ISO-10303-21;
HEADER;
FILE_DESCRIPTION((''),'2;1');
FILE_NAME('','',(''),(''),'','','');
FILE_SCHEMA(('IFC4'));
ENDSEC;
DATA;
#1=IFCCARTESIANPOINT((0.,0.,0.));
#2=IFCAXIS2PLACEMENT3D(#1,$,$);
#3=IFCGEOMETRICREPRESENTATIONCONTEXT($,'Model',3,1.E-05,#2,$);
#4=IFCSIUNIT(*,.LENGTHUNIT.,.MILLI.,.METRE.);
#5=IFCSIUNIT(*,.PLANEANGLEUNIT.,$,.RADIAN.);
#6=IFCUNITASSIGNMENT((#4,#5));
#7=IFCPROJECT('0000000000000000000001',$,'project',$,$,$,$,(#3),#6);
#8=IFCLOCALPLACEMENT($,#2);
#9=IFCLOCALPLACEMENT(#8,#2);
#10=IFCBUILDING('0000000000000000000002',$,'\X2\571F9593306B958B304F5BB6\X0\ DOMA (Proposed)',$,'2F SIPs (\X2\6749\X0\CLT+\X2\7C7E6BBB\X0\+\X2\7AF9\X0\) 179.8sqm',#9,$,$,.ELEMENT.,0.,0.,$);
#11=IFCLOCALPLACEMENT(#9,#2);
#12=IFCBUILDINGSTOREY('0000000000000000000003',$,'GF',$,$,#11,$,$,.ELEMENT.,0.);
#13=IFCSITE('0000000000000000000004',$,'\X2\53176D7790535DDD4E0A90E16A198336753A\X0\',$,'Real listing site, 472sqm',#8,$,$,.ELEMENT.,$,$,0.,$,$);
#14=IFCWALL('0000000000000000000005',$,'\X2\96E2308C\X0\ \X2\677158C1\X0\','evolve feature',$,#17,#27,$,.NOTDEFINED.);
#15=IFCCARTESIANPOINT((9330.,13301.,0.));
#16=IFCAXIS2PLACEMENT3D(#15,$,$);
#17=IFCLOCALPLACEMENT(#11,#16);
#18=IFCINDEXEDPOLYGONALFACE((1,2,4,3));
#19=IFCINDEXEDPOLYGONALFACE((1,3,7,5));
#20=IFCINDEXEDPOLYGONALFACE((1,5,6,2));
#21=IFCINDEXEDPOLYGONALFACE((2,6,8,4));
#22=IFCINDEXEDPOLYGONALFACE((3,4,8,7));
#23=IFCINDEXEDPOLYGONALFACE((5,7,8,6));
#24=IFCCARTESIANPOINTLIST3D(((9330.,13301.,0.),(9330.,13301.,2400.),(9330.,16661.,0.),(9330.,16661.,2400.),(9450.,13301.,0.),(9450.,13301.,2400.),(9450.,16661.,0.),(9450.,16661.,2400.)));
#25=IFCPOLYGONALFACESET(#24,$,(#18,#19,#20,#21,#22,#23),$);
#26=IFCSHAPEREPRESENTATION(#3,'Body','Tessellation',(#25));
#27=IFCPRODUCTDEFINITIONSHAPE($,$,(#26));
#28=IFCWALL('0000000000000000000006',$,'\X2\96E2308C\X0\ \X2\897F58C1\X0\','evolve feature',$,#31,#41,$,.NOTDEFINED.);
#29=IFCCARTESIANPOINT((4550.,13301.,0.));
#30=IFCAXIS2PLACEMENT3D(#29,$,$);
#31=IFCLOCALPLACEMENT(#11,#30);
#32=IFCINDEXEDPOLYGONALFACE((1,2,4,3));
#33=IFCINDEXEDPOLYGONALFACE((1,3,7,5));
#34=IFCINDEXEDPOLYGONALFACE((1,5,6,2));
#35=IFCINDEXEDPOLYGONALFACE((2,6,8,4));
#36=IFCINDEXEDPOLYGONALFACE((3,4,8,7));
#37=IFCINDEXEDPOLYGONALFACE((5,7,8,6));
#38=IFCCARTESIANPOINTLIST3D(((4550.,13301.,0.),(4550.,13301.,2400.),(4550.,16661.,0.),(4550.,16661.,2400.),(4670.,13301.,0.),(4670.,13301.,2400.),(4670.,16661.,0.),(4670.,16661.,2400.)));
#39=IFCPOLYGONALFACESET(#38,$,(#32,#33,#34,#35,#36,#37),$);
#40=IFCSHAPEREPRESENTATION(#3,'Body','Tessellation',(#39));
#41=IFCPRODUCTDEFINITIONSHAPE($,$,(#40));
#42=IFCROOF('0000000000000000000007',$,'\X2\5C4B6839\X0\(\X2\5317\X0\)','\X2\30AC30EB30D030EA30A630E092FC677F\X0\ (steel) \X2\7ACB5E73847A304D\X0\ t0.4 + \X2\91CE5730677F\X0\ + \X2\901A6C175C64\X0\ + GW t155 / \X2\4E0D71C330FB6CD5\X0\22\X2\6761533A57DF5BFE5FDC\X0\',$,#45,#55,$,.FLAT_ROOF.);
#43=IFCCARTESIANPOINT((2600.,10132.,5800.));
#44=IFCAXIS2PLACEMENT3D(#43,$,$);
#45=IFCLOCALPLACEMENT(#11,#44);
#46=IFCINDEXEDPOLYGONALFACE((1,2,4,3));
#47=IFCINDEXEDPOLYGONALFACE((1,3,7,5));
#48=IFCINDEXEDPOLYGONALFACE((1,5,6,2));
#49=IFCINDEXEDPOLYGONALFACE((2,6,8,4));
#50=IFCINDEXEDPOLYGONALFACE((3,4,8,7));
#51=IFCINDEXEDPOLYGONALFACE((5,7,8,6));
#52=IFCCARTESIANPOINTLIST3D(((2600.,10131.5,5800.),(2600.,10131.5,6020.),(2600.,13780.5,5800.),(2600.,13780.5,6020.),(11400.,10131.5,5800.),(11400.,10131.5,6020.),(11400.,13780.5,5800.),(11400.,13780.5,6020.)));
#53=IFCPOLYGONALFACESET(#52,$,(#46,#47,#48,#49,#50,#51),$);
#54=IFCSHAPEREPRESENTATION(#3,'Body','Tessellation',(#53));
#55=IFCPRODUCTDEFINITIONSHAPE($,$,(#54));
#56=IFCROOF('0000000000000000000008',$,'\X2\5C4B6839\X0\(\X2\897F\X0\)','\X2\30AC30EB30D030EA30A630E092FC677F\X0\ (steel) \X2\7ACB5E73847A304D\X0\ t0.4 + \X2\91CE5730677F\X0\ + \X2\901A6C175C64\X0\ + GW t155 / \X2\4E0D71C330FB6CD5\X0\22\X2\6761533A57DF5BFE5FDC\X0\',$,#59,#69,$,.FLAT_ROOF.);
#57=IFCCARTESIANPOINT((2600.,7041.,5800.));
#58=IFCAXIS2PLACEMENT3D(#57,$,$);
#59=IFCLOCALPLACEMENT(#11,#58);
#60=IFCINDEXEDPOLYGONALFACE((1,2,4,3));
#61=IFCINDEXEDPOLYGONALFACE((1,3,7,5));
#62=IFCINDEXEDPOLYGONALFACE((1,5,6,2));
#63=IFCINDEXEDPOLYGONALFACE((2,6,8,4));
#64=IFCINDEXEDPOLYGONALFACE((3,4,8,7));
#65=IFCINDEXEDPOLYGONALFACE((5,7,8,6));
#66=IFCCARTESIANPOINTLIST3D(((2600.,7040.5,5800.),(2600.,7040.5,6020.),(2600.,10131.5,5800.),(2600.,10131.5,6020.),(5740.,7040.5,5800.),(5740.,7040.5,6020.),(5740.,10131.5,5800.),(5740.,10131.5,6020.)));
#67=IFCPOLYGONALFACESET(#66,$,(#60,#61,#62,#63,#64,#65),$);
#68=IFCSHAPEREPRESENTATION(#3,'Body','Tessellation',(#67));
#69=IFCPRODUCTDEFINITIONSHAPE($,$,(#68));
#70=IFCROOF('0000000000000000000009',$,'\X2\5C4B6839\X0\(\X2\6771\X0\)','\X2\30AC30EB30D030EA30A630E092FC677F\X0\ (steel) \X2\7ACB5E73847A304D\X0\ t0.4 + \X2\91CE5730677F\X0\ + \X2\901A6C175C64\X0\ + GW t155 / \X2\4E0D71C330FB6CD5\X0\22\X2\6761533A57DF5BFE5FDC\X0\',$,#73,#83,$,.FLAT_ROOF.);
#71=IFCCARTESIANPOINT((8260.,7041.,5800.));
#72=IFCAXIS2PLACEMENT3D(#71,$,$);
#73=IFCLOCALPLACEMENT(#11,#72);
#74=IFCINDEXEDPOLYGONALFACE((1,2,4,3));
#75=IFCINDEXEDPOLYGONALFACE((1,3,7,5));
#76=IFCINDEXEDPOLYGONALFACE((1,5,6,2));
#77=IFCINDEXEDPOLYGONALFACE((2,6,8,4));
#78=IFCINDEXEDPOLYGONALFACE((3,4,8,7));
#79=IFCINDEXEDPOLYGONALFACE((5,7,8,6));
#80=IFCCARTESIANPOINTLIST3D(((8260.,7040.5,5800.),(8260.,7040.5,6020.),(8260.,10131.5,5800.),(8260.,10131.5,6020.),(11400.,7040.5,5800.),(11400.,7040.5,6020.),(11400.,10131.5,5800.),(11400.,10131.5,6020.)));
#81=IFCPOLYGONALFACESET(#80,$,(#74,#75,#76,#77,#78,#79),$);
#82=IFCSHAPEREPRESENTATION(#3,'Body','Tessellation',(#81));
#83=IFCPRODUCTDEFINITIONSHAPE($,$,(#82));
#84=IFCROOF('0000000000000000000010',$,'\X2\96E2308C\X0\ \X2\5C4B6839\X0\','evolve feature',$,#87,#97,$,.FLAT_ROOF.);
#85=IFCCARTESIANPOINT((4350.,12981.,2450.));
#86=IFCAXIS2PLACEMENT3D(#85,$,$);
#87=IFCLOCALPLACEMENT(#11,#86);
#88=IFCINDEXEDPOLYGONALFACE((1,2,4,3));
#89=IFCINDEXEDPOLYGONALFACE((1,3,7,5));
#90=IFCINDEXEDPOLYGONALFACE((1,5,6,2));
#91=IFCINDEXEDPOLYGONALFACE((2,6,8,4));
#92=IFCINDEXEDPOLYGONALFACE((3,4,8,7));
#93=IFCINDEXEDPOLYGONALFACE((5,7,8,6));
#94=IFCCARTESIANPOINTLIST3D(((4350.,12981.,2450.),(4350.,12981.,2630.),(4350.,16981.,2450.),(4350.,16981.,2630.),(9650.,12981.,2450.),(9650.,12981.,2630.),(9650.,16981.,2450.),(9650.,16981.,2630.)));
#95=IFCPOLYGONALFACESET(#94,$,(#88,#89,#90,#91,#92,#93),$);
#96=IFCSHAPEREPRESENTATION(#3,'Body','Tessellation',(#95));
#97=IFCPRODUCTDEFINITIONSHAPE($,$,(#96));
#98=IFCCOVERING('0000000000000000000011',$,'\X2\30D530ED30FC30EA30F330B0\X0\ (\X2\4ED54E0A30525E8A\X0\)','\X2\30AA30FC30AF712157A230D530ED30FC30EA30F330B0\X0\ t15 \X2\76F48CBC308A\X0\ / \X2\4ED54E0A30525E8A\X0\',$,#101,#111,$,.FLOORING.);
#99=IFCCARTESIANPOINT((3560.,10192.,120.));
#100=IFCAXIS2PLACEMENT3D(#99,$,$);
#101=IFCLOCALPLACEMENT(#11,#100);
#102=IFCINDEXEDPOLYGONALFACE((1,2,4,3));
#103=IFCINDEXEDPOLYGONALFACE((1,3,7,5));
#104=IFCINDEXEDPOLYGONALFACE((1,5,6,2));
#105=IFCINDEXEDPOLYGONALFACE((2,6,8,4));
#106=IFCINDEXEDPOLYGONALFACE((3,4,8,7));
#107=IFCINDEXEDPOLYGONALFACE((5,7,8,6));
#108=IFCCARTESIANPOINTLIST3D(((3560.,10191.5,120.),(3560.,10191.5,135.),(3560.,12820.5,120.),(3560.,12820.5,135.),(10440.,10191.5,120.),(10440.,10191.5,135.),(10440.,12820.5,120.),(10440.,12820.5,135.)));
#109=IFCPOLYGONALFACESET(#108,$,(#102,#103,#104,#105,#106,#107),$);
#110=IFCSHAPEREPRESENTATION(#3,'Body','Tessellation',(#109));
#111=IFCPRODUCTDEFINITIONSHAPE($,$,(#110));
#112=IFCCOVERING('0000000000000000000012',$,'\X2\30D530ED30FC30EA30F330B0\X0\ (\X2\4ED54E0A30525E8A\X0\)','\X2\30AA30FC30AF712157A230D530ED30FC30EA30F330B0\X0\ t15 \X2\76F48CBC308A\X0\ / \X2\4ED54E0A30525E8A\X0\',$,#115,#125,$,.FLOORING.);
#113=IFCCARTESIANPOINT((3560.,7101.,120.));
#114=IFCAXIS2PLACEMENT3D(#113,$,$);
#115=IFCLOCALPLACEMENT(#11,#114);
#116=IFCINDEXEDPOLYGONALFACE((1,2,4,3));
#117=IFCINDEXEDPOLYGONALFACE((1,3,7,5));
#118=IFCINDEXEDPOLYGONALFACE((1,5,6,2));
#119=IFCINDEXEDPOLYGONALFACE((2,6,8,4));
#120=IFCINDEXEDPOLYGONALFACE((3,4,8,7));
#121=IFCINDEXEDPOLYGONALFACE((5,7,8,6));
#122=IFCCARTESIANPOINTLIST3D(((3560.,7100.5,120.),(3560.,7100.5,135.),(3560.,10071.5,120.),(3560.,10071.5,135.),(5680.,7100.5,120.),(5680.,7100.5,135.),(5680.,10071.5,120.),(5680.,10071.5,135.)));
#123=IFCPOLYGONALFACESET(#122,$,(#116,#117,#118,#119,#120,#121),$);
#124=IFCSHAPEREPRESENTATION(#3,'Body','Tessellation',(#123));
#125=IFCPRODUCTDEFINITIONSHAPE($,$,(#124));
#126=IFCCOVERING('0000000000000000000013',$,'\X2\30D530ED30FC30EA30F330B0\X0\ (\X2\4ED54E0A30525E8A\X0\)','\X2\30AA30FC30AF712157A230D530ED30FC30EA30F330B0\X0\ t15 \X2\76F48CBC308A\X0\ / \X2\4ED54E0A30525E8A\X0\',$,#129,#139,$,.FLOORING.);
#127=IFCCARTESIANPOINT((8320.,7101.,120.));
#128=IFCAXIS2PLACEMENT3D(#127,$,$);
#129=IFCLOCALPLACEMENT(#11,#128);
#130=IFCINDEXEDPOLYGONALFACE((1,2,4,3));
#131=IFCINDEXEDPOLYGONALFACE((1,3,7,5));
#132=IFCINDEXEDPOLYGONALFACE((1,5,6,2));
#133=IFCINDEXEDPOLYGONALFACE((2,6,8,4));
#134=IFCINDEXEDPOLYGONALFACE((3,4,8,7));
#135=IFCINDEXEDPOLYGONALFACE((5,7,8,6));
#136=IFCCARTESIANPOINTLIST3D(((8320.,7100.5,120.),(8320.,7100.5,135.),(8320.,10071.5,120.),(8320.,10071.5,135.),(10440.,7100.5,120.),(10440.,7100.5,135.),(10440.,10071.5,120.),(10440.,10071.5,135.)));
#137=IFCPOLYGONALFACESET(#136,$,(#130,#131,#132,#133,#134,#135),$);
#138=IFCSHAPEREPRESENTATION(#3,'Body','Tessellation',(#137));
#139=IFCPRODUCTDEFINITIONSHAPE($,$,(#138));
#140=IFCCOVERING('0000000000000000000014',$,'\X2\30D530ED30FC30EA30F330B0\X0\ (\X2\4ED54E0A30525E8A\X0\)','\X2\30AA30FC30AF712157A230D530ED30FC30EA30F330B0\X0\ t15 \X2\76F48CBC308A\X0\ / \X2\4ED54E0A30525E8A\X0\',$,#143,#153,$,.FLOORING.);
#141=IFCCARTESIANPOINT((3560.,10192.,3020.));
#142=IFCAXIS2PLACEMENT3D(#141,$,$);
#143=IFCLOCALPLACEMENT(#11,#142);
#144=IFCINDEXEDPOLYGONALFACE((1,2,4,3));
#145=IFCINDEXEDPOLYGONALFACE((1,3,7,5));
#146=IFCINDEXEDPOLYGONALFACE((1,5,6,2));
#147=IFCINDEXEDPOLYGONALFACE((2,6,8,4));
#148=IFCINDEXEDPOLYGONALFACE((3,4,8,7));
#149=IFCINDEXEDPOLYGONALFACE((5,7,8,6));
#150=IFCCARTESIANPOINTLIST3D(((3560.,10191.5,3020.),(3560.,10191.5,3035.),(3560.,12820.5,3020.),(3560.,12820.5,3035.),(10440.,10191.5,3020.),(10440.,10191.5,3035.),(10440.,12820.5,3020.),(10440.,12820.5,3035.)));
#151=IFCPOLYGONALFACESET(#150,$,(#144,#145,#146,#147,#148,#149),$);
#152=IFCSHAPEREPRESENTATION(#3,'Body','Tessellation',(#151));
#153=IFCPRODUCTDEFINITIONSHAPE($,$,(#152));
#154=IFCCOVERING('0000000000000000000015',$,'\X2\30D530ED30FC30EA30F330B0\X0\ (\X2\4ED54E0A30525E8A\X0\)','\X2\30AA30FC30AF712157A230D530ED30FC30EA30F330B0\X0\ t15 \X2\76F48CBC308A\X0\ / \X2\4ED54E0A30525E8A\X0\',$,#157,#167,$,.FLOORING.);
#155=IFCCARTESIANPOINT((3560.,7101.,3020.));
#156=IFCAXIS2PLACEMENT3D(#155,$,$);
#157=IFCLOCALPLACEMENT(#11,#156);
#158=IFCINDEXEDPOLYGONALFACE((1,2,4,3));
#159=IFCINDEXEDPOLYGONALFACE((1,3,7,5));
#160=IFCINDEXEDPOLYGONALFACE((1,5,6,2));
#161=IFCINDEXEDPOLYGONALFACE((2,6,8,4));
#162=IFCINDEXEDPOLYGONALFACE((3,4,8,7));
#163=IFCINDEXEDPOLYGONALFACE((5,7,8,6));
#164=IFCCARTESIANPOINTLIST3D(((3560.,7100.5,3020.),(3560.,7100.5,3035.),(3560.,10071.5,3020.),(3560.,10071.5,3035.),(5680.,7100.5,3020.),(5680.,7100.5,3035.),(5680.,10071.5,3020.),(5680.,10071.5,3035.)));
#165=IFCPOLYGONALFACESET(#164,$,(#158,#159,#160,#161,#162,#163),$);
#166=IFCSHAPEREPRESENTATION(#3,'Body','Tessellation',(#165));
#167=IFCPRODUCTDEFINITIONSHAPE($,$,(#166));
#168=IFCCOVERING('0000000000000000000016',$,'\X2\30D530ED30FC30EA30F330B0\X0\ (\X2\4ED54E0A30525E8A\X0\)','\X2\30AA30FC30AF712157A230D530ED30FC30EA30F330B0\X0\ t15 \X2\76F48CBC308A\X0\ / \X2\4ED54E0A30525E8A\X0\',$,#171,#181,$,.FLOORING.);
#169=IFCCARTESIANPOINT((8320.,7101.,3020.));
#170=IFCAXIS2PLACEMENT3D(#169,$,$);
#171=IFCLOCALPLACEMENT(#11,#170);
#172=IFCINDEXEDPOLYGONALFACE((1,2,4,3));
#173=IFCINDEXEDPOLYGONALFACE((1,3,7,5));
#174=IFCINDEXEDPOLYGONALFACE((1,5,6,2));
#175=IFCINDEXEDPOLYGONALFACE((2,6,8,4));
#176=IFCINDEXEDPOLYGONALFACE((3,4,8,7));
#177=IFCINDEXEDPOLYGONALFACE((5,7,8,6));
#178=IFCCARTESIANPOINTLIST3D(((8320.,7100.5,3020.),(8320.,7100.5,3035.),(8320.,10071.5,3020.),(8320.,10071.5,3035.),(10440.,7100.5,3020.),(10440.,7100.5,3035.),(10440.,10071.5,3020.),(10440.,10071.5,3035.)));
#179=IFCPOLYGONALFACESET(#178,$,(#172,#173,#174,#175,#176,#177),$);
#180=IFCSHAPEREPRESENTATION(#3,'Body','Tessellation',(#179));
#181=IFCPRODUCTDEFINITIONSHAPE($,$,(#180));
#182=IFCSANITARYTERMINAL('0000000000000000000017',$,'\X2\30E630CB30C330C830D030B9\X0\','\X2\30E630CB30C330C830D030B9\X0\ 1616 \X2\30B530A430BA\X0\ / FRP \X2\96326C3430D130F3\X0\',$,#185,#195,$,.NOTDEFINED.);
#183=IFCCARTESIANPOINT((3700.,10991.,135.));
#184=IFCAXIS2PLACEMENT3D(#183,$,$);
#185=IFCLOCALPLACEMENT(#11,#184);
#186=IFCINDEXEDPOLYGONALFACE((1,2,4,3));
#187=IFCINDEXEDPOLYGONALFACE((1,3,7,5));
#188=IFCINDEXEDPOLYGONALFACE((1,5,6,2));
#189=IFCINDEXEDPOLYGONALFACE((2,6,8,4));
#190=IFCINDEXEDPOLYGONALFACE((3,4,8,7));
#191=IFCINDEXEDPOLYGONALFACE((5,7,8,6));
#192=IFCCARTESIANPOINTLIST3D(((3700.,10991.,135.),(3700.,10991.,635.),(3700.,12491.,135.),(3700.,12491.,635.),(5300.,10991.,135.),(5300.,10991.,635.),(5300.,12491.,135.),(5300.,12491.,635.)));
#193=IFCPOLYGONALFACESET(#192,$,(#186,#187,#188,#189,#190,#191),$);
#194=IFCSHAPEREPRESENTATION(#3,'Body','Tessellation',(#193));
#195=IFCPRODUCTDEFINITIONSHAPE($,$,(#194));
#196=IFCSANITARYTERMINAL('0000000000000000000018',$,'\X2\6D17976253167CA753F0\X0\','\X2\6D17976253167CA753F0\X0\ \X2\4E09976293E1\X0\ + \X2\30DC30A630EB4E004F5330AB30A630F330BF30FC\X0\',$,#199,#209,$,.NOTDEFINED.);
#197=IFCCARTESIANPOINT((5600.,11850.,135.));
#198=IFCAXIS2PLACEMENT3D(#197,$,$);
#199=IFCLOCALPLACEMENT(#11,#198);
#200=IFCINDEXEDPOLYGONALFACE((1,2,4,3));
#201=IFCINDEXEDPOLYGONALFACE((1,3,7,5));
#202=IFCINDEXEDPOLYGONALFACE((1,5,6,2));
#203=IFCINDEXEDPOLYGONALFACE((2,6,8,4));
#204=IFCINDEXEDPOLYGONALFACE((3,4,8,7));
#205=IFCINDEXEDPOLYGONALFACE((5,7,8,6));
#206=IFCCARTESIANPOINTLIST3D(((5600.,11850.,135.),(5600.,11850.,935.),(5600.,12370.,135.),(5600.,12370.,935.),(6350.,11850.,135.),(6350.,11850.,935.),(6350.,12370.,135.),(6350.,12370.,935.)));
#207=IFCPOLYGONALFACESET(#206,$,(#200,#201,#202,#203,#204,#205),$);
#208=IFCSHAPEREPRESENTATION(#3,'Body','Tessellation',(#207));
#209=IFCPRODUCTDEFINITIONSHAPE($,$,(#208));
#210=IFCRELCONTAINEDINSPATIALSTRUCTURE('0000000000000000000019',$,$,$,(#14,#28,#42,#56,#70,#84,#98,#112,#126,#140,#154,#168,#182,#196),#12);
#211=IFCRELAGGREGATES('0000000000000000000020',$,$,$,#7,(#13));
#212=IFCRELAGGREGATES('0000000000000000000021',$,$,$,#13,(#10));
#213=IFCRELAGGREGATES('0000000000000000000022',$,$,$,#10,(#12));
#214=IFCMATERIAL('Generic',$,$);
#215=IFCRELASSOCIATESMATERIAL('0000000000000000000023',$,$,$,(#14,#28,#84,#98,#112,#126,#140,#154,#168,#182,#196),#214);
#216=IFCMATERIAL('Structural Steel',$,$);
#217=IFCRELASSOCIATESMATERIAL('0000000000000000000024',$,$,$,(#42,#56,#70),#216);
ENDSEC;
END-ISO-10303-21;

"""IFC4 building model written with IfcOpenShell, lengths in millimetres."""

from ifc_helpers import new_model, si_unit, frame, frame_2d, origin, place, context, project, spatial, rectangle, extrude, material, element, save


model = new_model("IFC4")

# Units and contexts
model_context = context("Model", 3, precision=1e-05, world=origin())
ifc_project = project(units=[si_unit("LENGTHUNIT", "METRE", prefix="MILLI"), si_unit("PLANEANGLEUNIT", "RADIAN")], contexts=[model_context])

# Site, building, storey
site_placement = place(None, origin())
site = spatial("IfcSite", under=ifc_project, at=site_placement, Name="北海道川上郡標茶町", ObjectType="Real listing site, 472sqm", CompositionType="ELEMENT", RefElevation=0.0)
building_placement = place(site_placement, origin())
building = spatial("IfcBuilding", under=site, at=building_placement, Name="土間に開く家 DOMA (Proposed)", ObjectType="2F SIPs (杉CLT+籾殻+竹) 179.8sqm", CompositionType="ELEMENT", ElevationOfRefHeight=0.0, ElevationOfTerrain=0.0)
storey_placement = place(building_placement, origin())
storey = spatial("IfcBuildingStorey", under=building, at=storey_placement, Name="GF", CompositionType="ELEMENT", Elevation=0.0)

# Shared definitions
ifc_material_1 = material(Name="Generic")

# Walls
wall_1_placement = place(storey_placement, frame((9330.0, 13301.0, 0.0)))
element("IfcWall", 1, at=wall_1_placement, inside=storey, material=ifc_material_1, Name="離れ 東壁", Description="evolve feature", PredefinedType="NOTDEFINED", context=model_context, shape_type="SweptSolid", body=[
    extrude(rectangle(XDim=120.0, YDim=3360.0, at=frame_2d((60.0, 1680.0))), frame((9330.0, 13301.0, 0.0)), (0.0, 0.0, 1.0), 2400.0),
])
wall_2_placement = place(storey_placement, frame((4550.0, 13301.0, 0.0)))
element("IfcWall", 2, at=wall_2_placement, inside=storey, material=ifc_material_1, Name="離れ 西壁", Description="evolve feature", PredefinedType="NOTDEFINED", context=model_context, shape_type="SweptSolid", body=[
    extrude(rectangle(XDim=120.0, YDim=3360.0, at=frame_2d((60.0, 1680.0))), frame((4550.0, 13301.0, 0.0)), (0.0, 0.0, 1.0), 2400.0),
])

# Roofs
ifc_material_2 = material(Name="Structural Steel")
for number, where, name in (
    (3, (2600.0, 10132.0, 5800.0), "屋根(北)"),
):
    element("IfcRoof", number, at=place(storey_placement, frame(where)), inside=storey, material=ifc_material_2, Name=name, Description="ガルバリウム鋼板 (steel) 立平葺き t0.4 + 野地板 + 通気層 + GW t155 / 不燃・法22条区域対応", PredefinedType="FLAT_ROOF", context=model_context, shape_type="SweptSolid", body=[
        extrude(rectangle(XDim=8800.0, YDim=3649.0, at=frame_2d((4400.0, 1824.0))), frame((2600.0, 10132.0, 5800.0)), (0.0, 0.0, 1.0), 220.0),
    ])
roof_1_placement = place(storey_placement, frame((2600.0, 7041.0, 5800.0)))
element("IfcRoof", 4, at=roof_1_placement, inside=storey, material=ifc_material_2, Name="屋根(西)", Description="ガルバリウム鋼板 (steel) 立平葺き t0.4 + 野地板 + 通気層 + GW t155 / 不燃・法22条区域対応", PredefinedType="FLAT_ROOF", context=model_context, shape_type="SweptSolid", body=[
    extrude(rectangle(XDim=3140.0, YDim=3091.0, at=frame_2d((1570.0, 1545.0))), frame((2600.0, 7041.0, 5800.0)), (0.0, 0.0, 1.0), 220.0),
])
roof_2_placement = place(storey_placement, frame((8260.0, 7041.0, 5800.0)))
element("IfcRoof", 5, at=roof_2_placement, inside=storey, material=ifc_material_2, Name="屋根(東)", Description="ガルバリウム鋼板 (steel) 立平葺き t0.4 + 野地板 + 通気層 + GW t155 / 不燃・法22条区域対応", PredefinedType="FLAT_ROOF", context=model_context, shape_type="SweptSolid", body=[
    extrude(rectangle(XDim=3140.0, YDim=3091.0, at=frame_2d((1570.0, 1545.0))), frame((8260.0, 7041.0, 5800.0)), (0.0, 0.0, 1.0), 220.0),
])
roof_3_placement = place(storey_placement, frame((4350.0, 12981.0, 2450.0)))
element("IfcRoof", 6, at=roof_3_placement, inside=storey, material=ifc_material_1, Name="離れ 屋根", Description="evolve feature", PredefinedType="FLAT_ROOF", context=model_context, shape_type="SweptSolid", body=[
    extrude(rectangle(XDim=5300.0, YDim=4000.0, at=frame_2d((2650.0, 2000.0))), frame((4350.0, 12981.0, 2450.0)), (0.0, 0.0, 1.0), 180.0),
])

# Coverings
covering_1_placement = place(storey_placement, frame((3560.0, 10192.0, 120.0)))
element("IfcCovering", 7, at=covering_1_placement, inside=storey, material=ifc_material_1, Name="フローリング (仕上げ床)", Description="オーク無垢フローリング t15 直貼り / 仕上げ床", PredefinedType="FLOORING", context=model_context, shape_type="SweptSolid", body=[
    extrude(rectangle(XDim=6880.0, YDim=2629.0, at=frame_2d((3440.0, 1314.0))), frame((3560.0, 10192.0, 120.0)), (0.0, 0.0, 1.0), 15.0),
])
covering_2_placement = place(storey_placement, frame((3560.0, 7101.0, 120.0)))
element("IfcCovering", 8, at=covering_2_placement, inside=storey, material=ifc_material_1, Name="フローリング (仕上げ床)", Description="オーク無垢フローリング t15 直貼り / 仕上げ床", PredefinedType="FLOORING", context=model_context, shape_type="SweptSolid", body=[
    extrude(rectangle(XDim=2120.0, YDim=2971.0, at=frame_2d((1060.0, 1485.0))), frame((3560.0, 7101.0, 120.0)), (0.0, 0.0, 1.0), 15.0),
])
covering_3_placement = place(storey_placement, frame((8320.0, 7101.0, 120.0)))
element("IfcCovering", 9, at=covering_3_placement, inside=storey, material=ifc_material_1, Name="フローリング (仕上げ床)", Description="オーク無垢フローリング t15 直貼り / 仕上げ床", PredefinedType="FLOORING", context=model_context, shape_type="SweptSolid", body=[
    extrude(rectangle(XDim=2120.0, YDim=2971.0, at=frame_2d((1060.0, 1485.0))), frame((8320.0, 7101.0, 120.0)), (0.0, 0.0, 1.0), 15.0),
])
covering_4_placement = place(storey_placement, frame((3560.0, 10192.0, 3020.0)))
element("IfcCovering", 10, at=covering_4_placement, inside=storey, material=ifc_material_1, Name="フローリング (仕上げ床)", Description="オーク無垢フローリング t15 直貼り / 仕上げ床", PredefinedType="FLOORING", context=model_context, shape_type="SweptSolid", body=[
    extrude(rectangle(XDim=6880.0, YDim=2629.0, at=frame_2d((3440.0, 1314.0))), frame((3560.0, 10192.0, 3020.0)), (0.0, 0.0, 1.0), 15.0),
])
covering_5_placement = place(storey_placement, frame((3560.0, 7101.0, 3020.0)))
element("IfcCovering", 11, at=covering_5_placement, inside=storey, material=ifc_material_1, Name="フローリング (仕上げ床)", Description="オーク無垢フローリング t15 直貼り / 仕上げ床", PredefinedType="FLOORING", context=model_context, shape_type="SweptSolid", body=[
    extrude(rectangle(XDim=2120.0, YDim=2971.0, at=frame_2d((1060.0, 1485.0))), frame((3560.0, 7101.0, 3020.0)), (0.0, 0.0, 1.0), 15.0),
])
covering_6_placement = place(storey_placement, frame((8320.0, 7101.0, 3020.0)))
element("IfcCovering", 12, at=covering_6_placement, inside=storey, material=ifc_material_1, Name="フローリング (仕上げ床)", Description="オーク無垢フローリング t15 直貼り / 仕上げ床", PredefinedType="FLOORING", context=model_context, shape_type="SweptSolid", body=[
    extrude(rectangle(XDim=2120.0, YDim=2971.0, at=frame_2d((1060.0, 1485.0))), frame((8320.0, 7101.0, 3020.0)), (0.0, 0.0, 1.0), 15.0),
])

# Sanitary terminals
sanitary_terminal_1_placement = place(storey_placement, frame((3700.0, 10991.0, 135.0)))
element("IfcSanitaryTerminal", 13, at=sanitary_terminal_1_placement, inside=storey, material=ifc_material_1, Name="ユニットバス", Description="ユニットバス 1616 サイズ / FRP 防水パン", PredefinedType="NOTDEFINED", context=model_context, shape_type="SweptSolid", body=[
    extrude(rectangle(XDim=1600.0, YDim=1500.0, at=frame_2d((800.0, 750.0))), frame((3700.0, 10991.0, 135.0)), (0.0, 0.0, 1.0), 500.0),
])
sanitary_terminal_2_placement = place(storey_placement, frame((5600.0, 11850.0, 135.0)))
element("IfcSanitaryTerminal", 14, at=sanitary_terminal_2_placement, inside=storey, material=ifc_material_1, Name="洗面化粧台", Description="洗面化粧台 三面鏡 + ボウル一体カウンター", PredefinedType="NOTDEFINED", context=model_context, shape_type="SweptSolid", body=[
    extrude(rectangle(XDim=750.0, YDim=520.0, at=frame_2d((375.0, 260.0))), frame((5600.0, 11850.0, 135.0)), (0.0, 0.0, 1.0), 800.0),
])

save(model, "model.ifc")
